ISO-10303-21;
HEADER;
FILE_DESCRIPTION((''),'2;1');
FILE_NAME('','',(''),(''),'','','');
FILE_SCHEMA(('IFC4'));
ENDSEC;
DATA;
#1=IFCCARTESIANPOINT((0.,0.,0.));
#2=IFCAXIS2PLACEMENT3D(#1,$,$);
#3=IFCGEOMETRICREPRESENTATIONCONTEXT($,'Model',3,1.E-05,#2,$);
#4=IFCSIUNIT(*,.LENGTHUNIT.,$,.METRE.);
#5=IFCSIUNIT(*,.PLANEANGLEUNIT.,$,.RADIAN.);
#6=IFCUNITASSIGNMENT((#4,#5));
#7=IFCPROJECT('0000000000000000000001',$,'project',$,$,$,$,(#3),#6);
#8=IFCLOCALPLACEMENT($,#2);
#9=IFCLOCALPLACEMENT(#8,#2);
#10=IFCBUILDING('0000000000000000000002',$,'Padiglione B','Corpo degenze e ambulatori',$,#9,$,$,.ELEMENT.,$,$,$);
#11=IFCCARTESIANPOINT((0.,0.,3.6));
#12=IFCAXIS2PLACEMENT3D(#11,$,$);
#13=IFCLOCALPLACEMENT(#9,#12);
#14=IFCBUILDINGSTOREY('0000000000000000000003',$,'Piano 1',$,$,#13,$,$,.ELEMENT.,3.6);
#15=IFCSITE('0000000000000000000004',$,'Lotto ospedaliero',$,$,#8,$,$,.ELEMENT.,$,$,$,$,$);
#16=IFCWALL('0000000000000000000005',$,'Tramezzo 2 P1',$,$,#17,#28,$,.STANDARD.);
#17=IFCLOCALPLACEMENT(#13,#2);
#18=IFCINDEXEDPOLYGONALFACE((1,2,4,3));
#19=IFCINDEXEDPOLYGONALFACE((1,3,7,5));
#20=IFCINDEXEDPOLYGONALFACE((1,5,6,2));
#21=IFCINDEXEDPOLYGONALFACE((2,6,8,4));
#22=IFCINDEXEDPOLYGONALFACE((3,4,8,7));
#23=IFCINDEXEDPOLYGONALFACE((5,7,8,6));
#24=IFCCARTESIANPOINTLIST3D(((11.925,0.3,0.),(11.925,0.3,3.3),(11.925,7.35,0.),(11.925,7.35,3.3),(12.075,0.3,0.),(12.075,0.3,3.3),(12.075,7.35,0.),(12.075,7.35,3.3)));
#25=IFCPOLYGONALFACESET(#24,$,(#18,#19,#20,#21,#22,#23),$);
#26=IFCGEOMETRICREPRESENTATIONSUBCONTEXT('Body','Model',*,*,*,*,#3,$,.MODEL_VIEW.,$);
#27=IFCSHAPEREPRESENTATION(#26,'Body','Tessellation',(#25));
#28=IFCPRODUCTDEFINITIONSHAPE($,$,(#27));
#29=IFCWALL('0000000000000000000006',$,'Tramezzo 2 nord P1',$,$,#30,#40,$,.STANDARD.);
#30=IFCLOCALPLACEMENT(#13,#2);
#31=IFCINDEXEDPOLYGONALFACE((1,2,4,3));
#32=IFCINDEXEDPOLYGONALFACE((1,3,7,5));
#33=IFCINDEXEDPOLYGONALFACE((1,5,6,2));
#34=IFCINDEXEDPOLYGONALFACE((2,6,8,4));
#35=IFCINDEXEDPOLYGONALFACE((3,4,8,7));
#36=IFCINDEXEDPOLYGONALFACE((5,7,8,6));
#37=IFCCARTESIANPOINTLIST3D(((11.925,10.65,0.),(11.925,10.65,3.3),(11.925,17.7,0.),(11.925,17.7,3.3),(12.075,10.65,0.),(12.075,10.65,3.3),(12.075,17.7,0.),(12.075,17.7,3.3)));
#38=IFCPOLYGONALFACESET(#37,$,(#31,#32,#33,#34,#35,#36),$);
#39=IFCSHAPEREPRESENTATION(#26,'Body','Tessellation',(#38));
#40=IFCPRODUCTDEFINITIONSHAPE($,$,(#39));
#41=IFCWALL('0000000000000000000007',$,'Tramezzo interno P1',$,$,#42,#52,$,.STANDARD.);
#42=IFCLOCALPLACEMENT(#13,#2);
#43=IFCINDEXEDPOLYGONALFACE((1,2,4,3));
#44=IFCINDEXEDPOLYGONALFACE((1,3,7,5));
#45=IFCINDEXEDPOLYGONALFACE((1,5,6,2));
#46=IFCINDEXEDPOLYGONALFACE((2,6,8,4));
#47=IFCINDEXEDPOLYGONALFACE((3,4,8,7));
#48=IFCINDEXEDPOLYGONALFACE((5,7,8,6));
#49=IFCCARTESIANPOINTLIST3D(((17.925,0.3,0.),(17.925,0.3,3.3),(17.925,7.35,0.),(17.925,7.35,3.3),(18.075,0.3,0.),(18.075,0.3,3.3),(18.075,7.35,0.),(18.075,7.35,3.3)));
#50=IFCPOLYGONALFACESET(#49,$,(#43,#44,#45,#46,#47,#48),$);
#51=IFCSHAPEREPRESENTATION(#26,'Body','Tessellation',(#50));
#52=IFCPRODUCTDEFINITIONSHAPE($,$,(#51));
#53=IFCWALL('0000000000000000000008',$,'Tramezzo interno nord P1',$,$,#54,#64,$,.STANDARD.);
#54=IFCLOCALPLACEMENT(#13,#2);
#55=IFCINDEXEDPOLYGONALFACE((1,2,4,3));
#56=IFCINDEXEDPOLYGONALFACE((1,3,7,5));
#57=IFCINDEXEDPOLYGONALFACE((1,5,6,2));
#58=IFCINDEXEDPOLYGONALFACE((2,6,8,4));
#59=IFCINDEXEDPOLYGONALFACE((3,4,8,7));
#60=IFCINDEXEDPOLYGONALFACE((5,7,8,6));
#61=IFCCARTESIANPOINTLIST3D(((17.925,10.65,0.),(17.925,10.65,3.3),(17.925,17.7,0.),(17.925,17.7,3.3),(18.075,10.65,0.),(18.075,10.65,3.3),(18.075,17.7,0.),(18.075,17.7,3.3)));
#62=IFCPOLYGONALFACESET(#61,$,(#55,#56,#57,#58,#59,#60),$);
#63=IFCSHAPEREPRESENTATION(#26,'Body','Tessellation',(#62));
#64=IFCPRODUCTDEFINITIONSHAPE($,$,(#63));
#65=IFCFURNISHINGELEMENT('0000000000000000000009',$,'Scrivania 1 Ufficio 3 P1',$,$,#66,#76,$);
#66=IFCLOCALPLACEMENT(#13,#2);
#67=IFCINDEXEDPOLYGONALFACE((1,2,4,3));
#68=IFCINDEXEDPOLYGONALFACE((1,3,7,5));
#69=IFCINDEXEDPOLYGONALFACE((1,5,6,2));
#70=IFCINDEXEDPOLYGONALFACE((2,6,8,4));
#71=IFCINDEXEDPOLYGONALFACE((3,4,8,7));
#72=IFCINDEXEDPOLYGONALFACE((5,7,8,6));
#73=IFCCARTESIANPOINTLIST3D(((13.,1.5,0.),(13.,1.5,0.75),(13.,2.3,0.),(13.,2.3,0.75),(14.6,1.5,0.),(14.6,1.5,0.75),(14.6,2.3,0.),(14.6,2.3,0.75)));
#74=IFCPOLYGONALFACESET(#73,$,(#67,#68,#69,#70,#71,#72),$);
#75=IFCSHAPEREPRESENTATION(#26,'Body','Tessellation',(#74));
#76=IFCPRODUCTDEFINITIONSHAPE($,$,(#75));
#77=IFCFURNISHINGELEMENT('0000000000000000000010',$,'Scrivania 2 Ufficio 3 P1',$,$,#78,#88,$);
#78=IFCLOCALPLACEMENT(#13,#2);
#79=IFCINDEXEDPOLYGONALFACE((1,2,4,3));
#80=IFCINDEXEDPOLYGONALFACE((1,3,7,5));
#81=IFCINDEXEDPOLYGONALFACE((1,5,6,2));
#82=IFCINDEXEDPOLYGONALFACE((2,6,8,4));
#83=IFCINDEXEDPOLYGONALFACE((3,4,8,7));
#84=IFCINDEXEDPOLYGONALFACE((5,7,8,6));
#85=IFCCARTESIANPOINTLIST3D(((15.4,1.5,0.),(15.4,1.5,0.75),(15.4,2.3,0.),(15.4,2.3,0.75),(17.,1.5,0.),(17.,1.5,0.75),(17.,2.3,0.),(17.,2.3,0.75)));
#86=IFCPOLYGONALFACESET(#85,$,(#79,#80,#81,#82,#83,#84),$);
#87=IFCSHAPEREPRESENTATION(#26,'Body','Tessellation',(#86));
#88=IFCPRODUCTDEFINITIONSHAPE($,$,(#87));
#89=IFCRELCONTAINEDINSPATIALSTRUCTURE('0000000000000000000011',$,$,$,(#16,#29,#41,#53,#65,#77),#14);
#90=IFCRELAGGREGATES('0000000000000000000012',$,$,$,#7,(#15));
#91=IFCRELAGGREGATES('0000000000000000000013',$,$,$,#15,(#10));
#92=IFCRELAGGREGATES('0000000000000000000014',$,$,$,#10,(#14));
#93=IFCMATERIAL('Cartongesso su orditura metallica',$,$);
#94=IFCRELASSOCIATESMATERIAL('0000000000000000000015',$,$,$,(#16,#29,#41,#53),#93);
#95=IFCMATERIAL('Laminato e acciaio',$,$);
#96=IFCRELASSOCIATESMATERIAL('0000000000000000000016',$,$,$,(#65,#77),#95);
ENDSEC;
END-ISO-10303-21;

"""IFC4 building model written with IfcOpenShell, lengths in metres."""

from ifc_helpers import new_model, si_unit, frame, frame_2d, origin, place, context, subcontext, project, spatial, rectangle, extrude, material, element, save


model = new_model("IFC4")

# Units and contexts
model_context = context("Model", 3, precision=1e-05, world=origin())
body_context = subcontext(model_context, "Body", "Model", "MODEL_VIEW")
ifc_project = project(units=[si_unit("LENGTHUNIT", "METRE"), si_unit("PLANEANGLEUNIT", "RADIAN")], contexts=[model_context])

# Site, building, storey
site_placement = place(None, origin())
site = spatial("IfcSite", under=ifc_project, at=site_placement, Name="Lotto ospedaliero", CompositionType="ELEMENT")
building_placement = place(site_placement, origin())
building = spatial("IfcBuilding", under=site, at=building_placement, Name="Padiglione B", Description="Corpo degenze e ambulatori", CompositionType="ELEMENT")
storey_placement = place(building_placement, frame((0.0, 0.0, 3.6)))
storey = spatial("IfcBuildingStorey", under=building, at=storey_placement, Name="Piano 1", CompositionType="ELEMENT", Elevation=3.6)

# Walls
ifc_material_1 = material(Name="Cartongesso su orditura metallica")
for number, where, name in (
    (1, (11.925, 0.3, 0.0), "Tramezzo 2 P1"),
    (2, (11.925, 10.65, 0.0), "Tramezzo 2 nord P1"),
    (3, (17.925, 0.3, 0.0), "Tramezzo interno P1"),
    (4, (17.925, 10.65, 0.0), "Tramezzo interno nord P1"),
):
    element("IfcWall", number, at=place(storey_placement, frame(where)), inside=storey, material=ifc_material_1, Name=name, PredefinedType="STANDARD", context=body_context, shape_type="SweptSolid", body=[
        extrude(rectangle(XDim=0.15, YDim=7.05, at=frame_2d((0.075, 3.525))), origin(), (0.0, 0.0, 1.0), 3.3),
    ])

# Furnishing elements
ifc_material_2 = material(Name="Laminato e acciaio")
for number, where, name in (
    (5, (13.0, 1.5, 0.0), "Scrivania 1 Ufficio 3 P1"),
    (6, (15.4, 1.5, 0.0), "Scrivania 2 Ufficio 3 P1"),
):
    element("IfcFurnishingElement", number, at=place(storey_placement, frame(where)), inside=storey, material=ifc_material_2, Name=name, context=body_context, shape_type="SweptSolid", body=[
        extrude(rectangle(XDim=1.6, YDim=0.8, at=frame_2d((0.8, 0.4))), origin(), (0.0, 0.0, 1.0), 0.75),
    ])

save(model, "model.ifc")
